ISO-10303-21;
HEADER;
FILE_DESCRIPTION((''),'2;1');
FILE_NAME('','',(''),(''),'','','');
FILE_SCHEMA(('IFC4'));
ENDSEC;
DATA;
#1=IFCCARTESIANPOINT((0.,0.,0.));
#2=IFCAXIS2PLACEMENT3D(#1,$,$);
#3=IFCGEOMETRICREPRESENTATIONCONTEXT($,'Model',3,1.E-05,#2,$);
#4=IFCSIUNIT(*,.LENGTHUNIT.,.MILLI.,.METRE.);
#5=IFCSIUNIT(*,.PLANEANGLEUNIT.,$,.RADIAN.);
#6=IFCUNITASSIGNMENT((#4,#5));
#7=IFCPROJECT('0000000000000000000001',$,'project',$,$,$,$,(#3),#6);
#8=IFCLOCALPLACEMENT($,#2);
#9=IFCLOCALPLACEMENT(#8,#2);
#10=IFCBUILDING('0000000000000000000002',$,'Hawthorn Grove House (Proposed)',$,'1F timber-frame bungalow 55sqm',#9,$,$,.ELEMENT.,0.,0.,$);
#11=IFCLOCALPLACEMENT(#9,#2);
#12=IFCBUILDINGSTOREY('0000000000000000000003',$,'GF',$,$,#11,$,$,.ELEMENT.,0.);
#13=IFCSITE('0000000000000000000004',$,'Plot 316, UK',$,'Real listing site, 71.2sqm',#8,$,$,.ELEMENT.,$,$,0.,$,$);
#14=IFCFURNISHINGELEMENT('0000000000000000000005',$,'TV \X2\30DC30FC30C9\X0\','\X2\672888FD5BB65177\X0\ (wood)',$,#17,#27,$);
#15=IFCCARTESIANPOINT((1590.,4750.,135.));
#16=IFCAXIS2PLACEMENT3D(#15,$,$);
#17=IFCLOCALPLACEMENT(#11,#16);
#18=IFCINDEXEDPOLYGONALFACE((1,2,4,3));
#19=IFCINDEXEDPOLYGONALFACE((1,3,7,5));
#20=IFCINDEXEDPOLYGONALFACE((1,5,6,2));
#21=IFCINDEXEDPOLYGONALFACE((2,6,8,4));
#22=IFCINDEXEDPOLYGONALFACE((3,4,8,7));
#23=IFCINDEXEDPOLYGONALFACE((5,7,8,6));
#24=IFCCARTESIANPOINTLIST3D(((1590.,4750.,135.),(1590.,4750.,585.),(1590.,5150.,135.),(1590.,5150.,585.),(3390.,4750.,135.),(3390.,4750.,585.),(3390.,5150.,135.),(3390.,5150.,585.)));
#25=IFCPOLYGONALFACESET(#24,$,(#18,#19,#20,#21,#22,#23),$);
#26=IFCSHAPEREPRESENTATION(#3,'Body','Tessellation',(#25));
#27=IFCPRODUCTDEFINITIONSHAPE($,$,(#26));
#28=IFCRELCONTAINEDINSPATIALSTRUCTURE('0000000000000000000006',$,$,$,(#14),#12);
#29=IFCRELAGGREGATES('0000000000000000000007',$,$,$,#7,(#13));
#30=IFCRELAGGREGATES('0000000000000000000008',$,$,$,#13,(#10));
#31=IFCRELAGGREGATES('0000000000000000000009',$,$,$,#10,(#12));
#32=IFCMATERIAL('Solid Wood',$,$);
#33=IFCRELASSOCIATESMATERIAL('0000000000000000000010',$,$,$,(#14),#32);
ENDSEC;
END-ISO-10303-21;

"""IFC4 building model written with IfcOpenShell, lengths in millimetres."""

from ifc_helpers import new_model, si_unit, frame, frame_2d, origin, place, context, project, spatial, rectangle, extrude, material, element, save


model = new_model("IFC4")

# Units and contexts
model_context = context("Model", 3, precision=1e-05, world=origin())
ifc_project = project(units=[si_unit("LENGTHUNIT", "METRE", prefix="MILLI"), si_unit("PLANEANGLEUNIT", "RADIAN")], contexts=[model_context])

# Site, building, storey
site_placement = place(None, origin())
site = spatial("IfcSite", under=ifc_project, at=site_placement, Name="Plot 316, UK", ObjectType="Real listing site, 71.2sqm", CompositionType="ELEMENT", RefElevation=0.0)
building_placement = place(site_placement, origin())
building = spatial("IfcBuilding", under=site, at=building_placement, Name="Hawthorn Grove House (Proposed)", ObjectType="1F timber-frame bungalow 55sqm", CompositionType="ELEMENT", ElevationOfRefHeight=0.0, ElevationOfTerrain=0.0)
storey_placement = place(building_placement, origin())
storey = spatial("IfcBuildingStorey", under=building, at=storey_placement, Name="GF", CompositionType="ELEMENT", Elevation=0.0)

# Shared definitions
ifc_material_1 = material(Name="Solid Wood")

# Furnishing element
furnishing_1_placement = place(storey_placement, frame((1590.0, 4750.0, 135.0)))
element("IfcFurnishingElement", 1, at=furnishing_1_placement, inside=storey, material=ifc_material_1, Name="TV ボード", Description="木製家具 (wood)", context=model_context, shape_type="SweptSolid", body=[
    extrude(rectangle(XDim=1800.0, YDim=400.0, at=frame_2d((900.0, 200.0))), frame((1590.0, 4750.0, 135.0)), (0.0, 0.0, 1.0), 450.0),
])

save(model, "model.ifc")
